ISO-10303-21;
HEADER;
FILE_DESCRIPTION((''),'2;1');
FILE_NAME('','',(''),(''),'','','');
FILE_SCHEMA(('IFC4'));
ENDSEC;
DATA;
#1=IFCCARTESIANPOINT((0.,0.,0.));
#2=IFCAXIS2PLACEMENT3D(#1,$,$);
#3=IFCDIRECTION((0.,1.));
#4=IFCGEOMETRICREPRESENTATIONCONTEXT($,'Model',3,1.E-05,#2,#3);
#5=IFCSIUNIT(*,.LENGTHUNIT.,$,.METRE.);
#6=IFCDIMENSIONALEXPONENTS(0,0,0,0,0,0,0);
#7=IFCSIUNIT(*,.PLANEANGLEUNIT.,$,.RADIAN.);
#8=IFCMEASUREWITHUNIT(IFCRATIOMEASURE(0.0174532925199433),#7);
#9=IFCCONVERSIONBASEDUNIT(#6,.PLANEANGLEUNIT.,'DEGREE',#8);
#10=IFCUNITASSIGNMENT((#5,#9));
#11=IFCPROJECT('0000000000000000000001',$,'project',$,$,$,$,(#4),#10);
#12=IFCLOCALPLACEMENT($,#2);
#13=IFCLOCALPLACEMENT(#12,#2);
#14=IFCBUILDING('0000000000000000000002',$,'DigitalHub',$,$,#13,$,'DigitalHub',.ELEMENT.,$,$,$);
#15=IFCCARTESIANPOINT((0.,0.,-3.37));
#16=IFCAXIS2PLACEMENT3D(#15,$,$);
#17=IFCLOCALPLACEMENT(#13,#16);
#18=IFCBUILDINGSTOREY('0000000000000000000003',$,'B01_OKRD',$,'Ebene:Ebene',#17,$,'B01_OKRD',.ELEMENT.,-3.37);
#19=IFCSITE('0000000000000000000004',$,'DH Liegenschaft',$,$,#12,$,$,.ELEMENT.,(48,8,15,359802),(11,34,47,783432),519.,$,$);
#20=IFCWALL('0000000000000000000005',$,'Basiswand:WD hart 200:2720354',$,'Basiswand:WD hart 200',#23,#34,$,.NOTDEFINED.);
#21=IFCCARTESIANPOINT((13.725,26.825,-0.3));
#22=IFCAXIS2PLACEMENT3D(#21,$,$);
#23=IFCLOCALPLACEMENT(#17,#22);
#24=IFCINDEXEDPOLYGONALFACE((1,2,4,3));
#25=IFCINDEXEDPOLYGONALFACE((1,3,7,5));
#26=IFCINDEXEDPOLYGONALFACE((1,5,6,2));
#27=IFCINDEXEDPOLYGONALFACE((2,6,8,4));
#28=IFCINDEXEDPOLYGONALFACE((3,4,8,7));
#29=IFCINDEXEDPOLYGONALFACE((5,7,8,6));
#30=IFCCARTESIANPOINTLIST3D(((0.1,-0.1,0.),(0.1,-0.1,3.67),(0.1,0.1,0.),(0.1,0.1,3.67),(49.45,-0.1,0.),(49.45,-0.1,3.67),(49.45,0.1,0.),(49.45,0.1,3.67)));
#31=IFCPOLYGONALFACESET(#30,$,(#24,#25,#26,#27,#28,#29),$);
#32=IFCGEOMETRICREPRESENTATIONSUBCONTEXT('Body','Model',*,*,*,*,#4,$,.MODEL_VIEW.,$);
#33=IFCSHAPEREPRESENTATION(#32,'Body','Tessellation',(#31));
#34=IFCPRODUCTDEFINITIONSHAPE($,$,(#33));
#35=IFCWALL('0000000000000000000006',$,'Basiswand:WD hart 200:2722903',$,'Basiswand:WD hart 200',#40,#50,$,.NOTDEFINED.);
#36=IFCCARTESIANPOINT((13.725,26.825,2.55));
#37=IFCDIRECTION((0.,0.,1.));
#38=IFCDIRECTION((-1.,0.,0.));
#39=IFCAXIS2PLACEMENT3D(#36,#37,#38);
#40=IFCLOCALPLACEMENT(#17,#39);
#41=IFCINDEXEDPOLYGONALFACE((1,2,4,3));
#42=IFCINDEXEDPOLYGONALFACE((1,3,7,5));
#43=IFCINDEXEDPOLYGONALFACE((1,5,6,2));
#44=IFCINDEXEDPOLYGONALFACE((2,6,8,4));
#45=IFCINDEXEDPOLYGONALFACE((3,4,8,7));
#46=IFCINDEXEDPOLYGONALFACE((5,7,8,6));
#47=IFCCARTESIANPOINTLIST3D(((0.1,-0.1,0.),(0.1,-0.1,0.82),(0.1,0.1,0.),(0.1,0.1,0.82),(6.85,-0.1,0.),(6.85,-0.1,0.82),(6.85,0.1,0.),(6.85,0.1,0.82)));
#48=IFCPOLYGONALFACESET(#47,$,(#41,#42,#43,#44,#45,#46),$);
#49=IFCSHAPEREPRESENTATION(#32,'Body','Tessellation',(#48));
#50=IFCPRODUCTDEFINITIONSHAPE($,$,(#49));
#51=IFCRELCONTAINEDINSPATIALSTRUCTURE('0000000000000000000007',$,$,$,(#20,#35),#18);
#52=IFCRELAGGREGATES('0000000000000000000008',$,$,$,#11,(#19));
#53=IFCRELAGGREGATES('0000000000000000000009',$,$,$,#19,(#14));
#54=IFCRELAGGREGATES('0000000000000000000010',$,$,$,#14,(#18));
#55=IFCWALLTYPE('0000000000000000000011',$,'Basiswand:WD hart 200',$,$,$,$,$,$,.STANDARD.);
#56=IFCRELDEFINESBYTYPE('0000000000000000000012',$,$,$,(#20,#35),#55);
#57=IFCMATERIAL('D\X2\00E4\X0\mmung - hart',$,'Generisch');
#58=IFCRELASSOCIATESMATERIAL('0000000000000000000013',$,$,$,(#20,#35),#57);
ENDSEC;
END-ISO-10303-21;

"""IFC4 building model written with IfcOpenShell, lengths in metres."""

from ifc_helpers import new_model, entity, si_unit, converted_unit, direction, frame, origin, place, context, subcontext, project, spatial, indexed_curve, outline, extrude, material, type_object, element, save


model = new_model("IFC4")

# Units and contexts
model_context = context("Model", 3, precision=1e-05, world=origin(), true_north=direction((0.0, 1.0)))
body_context = subcontext(model_context, "Body", "Model", "MODEL_VIEW")
ifc_project = project(units=[si_unit("LENGTHUNIT", "METRE"), converted_unit("PLANEANGLEUNIT", "DEGREE", entity("IfcRatioMeasure", 0.0174532925199433), si_unit("PLANEANGLEUNIT", "RADIAN"), dimensions=[0, 0, 0, 0, 0, 0, 0])], contexts=[model_context])

# Site, building, storey
site_placement = place(None, frame((0.0, 0.0, 0.0)))
site = spatial("IfcSite", under=ifc_project, at=site_placement, Name="DH Liegenschaft", CompositionType="ELEMENT", RefLatitude=(48, 8, 15, 359802), RefLongitude=(11, 34, 47, 783432), RefElevation=519.0)
building_placement = place(site_placement, origin())
building = spatial("IfcBuilding", under=site, at=building_placement, Name="DigitalHub", LongName="DigitalHub", CompositionType="ELEMENT")
storey_placement = place(building_placement, frame((0.0, 0.0, -3.37)))
storey = spatial("IfcBuildingStorey", under=building, at=storey_placement, Name="B01_OKRD", ObjectType="Ebene:Ebene", LongName="B01_OKRD", CompositionType="ELEMENT", Elevation=-3.37)

# Shared definitions
ifc_material_1 = material(Name="Dämmung - hart", Category="Generisch")

# Walls
wall_type_1 = type_object("IfcWallType", Name="Basiswand:WD hart 200", PredefinedType="STANDARD")
wall_1_placement = place(storey_placement, frame((13.725, 26.825, -0.3)))
element("IfcWall", 1, at=wall_1_placement, inside=storey, type_object=wall_type_1, material=ifc_material_1, Name="Basiswand:WD hart 200:2720354", ObjectType="Basiswand:WD hart 200", PredefinedType="NOTDEFINED", context=body_context, shape_type="SweptSolid", body=[
    extrude(outline(indexed_curve([(49.45, -0.1), (49.45, 0.1), (0.1, 0.1), (0.1, -0.1), (49.45, -0.1)], self_intersect=False)), origin(), (0.0, 0.0, 1.0), 3.67),
])
wall_2_placement = place(storey_placement, frame((13.725, 26.825, 2.55), z_axis=(0.0, 0.0, 1.0), x_axis=(-1.0, 0.0, 0.0)))
element("IfcWall", 2, at=wall_2_placement, inside=storey, type_object=wall_type_1, material=ifc_material_1, Name="Basiswand:WD hart 200:2722903", ObjectType="Basiswand:WD hart 200", PredefinedType="NOTDEFINED", context=body_context, shape_type="SweptSolid", body=[
    extrude(outline(indexed_curve([(6.85, -0.1), (6.85, 0.1), (0.1, 0.1), (0.1, -0.1), (6.85, -0.1)], self_intersect=False)), origin(), (0.0, 0.0, 1.0), 0.82),
])

save(model, "model.ifc")
